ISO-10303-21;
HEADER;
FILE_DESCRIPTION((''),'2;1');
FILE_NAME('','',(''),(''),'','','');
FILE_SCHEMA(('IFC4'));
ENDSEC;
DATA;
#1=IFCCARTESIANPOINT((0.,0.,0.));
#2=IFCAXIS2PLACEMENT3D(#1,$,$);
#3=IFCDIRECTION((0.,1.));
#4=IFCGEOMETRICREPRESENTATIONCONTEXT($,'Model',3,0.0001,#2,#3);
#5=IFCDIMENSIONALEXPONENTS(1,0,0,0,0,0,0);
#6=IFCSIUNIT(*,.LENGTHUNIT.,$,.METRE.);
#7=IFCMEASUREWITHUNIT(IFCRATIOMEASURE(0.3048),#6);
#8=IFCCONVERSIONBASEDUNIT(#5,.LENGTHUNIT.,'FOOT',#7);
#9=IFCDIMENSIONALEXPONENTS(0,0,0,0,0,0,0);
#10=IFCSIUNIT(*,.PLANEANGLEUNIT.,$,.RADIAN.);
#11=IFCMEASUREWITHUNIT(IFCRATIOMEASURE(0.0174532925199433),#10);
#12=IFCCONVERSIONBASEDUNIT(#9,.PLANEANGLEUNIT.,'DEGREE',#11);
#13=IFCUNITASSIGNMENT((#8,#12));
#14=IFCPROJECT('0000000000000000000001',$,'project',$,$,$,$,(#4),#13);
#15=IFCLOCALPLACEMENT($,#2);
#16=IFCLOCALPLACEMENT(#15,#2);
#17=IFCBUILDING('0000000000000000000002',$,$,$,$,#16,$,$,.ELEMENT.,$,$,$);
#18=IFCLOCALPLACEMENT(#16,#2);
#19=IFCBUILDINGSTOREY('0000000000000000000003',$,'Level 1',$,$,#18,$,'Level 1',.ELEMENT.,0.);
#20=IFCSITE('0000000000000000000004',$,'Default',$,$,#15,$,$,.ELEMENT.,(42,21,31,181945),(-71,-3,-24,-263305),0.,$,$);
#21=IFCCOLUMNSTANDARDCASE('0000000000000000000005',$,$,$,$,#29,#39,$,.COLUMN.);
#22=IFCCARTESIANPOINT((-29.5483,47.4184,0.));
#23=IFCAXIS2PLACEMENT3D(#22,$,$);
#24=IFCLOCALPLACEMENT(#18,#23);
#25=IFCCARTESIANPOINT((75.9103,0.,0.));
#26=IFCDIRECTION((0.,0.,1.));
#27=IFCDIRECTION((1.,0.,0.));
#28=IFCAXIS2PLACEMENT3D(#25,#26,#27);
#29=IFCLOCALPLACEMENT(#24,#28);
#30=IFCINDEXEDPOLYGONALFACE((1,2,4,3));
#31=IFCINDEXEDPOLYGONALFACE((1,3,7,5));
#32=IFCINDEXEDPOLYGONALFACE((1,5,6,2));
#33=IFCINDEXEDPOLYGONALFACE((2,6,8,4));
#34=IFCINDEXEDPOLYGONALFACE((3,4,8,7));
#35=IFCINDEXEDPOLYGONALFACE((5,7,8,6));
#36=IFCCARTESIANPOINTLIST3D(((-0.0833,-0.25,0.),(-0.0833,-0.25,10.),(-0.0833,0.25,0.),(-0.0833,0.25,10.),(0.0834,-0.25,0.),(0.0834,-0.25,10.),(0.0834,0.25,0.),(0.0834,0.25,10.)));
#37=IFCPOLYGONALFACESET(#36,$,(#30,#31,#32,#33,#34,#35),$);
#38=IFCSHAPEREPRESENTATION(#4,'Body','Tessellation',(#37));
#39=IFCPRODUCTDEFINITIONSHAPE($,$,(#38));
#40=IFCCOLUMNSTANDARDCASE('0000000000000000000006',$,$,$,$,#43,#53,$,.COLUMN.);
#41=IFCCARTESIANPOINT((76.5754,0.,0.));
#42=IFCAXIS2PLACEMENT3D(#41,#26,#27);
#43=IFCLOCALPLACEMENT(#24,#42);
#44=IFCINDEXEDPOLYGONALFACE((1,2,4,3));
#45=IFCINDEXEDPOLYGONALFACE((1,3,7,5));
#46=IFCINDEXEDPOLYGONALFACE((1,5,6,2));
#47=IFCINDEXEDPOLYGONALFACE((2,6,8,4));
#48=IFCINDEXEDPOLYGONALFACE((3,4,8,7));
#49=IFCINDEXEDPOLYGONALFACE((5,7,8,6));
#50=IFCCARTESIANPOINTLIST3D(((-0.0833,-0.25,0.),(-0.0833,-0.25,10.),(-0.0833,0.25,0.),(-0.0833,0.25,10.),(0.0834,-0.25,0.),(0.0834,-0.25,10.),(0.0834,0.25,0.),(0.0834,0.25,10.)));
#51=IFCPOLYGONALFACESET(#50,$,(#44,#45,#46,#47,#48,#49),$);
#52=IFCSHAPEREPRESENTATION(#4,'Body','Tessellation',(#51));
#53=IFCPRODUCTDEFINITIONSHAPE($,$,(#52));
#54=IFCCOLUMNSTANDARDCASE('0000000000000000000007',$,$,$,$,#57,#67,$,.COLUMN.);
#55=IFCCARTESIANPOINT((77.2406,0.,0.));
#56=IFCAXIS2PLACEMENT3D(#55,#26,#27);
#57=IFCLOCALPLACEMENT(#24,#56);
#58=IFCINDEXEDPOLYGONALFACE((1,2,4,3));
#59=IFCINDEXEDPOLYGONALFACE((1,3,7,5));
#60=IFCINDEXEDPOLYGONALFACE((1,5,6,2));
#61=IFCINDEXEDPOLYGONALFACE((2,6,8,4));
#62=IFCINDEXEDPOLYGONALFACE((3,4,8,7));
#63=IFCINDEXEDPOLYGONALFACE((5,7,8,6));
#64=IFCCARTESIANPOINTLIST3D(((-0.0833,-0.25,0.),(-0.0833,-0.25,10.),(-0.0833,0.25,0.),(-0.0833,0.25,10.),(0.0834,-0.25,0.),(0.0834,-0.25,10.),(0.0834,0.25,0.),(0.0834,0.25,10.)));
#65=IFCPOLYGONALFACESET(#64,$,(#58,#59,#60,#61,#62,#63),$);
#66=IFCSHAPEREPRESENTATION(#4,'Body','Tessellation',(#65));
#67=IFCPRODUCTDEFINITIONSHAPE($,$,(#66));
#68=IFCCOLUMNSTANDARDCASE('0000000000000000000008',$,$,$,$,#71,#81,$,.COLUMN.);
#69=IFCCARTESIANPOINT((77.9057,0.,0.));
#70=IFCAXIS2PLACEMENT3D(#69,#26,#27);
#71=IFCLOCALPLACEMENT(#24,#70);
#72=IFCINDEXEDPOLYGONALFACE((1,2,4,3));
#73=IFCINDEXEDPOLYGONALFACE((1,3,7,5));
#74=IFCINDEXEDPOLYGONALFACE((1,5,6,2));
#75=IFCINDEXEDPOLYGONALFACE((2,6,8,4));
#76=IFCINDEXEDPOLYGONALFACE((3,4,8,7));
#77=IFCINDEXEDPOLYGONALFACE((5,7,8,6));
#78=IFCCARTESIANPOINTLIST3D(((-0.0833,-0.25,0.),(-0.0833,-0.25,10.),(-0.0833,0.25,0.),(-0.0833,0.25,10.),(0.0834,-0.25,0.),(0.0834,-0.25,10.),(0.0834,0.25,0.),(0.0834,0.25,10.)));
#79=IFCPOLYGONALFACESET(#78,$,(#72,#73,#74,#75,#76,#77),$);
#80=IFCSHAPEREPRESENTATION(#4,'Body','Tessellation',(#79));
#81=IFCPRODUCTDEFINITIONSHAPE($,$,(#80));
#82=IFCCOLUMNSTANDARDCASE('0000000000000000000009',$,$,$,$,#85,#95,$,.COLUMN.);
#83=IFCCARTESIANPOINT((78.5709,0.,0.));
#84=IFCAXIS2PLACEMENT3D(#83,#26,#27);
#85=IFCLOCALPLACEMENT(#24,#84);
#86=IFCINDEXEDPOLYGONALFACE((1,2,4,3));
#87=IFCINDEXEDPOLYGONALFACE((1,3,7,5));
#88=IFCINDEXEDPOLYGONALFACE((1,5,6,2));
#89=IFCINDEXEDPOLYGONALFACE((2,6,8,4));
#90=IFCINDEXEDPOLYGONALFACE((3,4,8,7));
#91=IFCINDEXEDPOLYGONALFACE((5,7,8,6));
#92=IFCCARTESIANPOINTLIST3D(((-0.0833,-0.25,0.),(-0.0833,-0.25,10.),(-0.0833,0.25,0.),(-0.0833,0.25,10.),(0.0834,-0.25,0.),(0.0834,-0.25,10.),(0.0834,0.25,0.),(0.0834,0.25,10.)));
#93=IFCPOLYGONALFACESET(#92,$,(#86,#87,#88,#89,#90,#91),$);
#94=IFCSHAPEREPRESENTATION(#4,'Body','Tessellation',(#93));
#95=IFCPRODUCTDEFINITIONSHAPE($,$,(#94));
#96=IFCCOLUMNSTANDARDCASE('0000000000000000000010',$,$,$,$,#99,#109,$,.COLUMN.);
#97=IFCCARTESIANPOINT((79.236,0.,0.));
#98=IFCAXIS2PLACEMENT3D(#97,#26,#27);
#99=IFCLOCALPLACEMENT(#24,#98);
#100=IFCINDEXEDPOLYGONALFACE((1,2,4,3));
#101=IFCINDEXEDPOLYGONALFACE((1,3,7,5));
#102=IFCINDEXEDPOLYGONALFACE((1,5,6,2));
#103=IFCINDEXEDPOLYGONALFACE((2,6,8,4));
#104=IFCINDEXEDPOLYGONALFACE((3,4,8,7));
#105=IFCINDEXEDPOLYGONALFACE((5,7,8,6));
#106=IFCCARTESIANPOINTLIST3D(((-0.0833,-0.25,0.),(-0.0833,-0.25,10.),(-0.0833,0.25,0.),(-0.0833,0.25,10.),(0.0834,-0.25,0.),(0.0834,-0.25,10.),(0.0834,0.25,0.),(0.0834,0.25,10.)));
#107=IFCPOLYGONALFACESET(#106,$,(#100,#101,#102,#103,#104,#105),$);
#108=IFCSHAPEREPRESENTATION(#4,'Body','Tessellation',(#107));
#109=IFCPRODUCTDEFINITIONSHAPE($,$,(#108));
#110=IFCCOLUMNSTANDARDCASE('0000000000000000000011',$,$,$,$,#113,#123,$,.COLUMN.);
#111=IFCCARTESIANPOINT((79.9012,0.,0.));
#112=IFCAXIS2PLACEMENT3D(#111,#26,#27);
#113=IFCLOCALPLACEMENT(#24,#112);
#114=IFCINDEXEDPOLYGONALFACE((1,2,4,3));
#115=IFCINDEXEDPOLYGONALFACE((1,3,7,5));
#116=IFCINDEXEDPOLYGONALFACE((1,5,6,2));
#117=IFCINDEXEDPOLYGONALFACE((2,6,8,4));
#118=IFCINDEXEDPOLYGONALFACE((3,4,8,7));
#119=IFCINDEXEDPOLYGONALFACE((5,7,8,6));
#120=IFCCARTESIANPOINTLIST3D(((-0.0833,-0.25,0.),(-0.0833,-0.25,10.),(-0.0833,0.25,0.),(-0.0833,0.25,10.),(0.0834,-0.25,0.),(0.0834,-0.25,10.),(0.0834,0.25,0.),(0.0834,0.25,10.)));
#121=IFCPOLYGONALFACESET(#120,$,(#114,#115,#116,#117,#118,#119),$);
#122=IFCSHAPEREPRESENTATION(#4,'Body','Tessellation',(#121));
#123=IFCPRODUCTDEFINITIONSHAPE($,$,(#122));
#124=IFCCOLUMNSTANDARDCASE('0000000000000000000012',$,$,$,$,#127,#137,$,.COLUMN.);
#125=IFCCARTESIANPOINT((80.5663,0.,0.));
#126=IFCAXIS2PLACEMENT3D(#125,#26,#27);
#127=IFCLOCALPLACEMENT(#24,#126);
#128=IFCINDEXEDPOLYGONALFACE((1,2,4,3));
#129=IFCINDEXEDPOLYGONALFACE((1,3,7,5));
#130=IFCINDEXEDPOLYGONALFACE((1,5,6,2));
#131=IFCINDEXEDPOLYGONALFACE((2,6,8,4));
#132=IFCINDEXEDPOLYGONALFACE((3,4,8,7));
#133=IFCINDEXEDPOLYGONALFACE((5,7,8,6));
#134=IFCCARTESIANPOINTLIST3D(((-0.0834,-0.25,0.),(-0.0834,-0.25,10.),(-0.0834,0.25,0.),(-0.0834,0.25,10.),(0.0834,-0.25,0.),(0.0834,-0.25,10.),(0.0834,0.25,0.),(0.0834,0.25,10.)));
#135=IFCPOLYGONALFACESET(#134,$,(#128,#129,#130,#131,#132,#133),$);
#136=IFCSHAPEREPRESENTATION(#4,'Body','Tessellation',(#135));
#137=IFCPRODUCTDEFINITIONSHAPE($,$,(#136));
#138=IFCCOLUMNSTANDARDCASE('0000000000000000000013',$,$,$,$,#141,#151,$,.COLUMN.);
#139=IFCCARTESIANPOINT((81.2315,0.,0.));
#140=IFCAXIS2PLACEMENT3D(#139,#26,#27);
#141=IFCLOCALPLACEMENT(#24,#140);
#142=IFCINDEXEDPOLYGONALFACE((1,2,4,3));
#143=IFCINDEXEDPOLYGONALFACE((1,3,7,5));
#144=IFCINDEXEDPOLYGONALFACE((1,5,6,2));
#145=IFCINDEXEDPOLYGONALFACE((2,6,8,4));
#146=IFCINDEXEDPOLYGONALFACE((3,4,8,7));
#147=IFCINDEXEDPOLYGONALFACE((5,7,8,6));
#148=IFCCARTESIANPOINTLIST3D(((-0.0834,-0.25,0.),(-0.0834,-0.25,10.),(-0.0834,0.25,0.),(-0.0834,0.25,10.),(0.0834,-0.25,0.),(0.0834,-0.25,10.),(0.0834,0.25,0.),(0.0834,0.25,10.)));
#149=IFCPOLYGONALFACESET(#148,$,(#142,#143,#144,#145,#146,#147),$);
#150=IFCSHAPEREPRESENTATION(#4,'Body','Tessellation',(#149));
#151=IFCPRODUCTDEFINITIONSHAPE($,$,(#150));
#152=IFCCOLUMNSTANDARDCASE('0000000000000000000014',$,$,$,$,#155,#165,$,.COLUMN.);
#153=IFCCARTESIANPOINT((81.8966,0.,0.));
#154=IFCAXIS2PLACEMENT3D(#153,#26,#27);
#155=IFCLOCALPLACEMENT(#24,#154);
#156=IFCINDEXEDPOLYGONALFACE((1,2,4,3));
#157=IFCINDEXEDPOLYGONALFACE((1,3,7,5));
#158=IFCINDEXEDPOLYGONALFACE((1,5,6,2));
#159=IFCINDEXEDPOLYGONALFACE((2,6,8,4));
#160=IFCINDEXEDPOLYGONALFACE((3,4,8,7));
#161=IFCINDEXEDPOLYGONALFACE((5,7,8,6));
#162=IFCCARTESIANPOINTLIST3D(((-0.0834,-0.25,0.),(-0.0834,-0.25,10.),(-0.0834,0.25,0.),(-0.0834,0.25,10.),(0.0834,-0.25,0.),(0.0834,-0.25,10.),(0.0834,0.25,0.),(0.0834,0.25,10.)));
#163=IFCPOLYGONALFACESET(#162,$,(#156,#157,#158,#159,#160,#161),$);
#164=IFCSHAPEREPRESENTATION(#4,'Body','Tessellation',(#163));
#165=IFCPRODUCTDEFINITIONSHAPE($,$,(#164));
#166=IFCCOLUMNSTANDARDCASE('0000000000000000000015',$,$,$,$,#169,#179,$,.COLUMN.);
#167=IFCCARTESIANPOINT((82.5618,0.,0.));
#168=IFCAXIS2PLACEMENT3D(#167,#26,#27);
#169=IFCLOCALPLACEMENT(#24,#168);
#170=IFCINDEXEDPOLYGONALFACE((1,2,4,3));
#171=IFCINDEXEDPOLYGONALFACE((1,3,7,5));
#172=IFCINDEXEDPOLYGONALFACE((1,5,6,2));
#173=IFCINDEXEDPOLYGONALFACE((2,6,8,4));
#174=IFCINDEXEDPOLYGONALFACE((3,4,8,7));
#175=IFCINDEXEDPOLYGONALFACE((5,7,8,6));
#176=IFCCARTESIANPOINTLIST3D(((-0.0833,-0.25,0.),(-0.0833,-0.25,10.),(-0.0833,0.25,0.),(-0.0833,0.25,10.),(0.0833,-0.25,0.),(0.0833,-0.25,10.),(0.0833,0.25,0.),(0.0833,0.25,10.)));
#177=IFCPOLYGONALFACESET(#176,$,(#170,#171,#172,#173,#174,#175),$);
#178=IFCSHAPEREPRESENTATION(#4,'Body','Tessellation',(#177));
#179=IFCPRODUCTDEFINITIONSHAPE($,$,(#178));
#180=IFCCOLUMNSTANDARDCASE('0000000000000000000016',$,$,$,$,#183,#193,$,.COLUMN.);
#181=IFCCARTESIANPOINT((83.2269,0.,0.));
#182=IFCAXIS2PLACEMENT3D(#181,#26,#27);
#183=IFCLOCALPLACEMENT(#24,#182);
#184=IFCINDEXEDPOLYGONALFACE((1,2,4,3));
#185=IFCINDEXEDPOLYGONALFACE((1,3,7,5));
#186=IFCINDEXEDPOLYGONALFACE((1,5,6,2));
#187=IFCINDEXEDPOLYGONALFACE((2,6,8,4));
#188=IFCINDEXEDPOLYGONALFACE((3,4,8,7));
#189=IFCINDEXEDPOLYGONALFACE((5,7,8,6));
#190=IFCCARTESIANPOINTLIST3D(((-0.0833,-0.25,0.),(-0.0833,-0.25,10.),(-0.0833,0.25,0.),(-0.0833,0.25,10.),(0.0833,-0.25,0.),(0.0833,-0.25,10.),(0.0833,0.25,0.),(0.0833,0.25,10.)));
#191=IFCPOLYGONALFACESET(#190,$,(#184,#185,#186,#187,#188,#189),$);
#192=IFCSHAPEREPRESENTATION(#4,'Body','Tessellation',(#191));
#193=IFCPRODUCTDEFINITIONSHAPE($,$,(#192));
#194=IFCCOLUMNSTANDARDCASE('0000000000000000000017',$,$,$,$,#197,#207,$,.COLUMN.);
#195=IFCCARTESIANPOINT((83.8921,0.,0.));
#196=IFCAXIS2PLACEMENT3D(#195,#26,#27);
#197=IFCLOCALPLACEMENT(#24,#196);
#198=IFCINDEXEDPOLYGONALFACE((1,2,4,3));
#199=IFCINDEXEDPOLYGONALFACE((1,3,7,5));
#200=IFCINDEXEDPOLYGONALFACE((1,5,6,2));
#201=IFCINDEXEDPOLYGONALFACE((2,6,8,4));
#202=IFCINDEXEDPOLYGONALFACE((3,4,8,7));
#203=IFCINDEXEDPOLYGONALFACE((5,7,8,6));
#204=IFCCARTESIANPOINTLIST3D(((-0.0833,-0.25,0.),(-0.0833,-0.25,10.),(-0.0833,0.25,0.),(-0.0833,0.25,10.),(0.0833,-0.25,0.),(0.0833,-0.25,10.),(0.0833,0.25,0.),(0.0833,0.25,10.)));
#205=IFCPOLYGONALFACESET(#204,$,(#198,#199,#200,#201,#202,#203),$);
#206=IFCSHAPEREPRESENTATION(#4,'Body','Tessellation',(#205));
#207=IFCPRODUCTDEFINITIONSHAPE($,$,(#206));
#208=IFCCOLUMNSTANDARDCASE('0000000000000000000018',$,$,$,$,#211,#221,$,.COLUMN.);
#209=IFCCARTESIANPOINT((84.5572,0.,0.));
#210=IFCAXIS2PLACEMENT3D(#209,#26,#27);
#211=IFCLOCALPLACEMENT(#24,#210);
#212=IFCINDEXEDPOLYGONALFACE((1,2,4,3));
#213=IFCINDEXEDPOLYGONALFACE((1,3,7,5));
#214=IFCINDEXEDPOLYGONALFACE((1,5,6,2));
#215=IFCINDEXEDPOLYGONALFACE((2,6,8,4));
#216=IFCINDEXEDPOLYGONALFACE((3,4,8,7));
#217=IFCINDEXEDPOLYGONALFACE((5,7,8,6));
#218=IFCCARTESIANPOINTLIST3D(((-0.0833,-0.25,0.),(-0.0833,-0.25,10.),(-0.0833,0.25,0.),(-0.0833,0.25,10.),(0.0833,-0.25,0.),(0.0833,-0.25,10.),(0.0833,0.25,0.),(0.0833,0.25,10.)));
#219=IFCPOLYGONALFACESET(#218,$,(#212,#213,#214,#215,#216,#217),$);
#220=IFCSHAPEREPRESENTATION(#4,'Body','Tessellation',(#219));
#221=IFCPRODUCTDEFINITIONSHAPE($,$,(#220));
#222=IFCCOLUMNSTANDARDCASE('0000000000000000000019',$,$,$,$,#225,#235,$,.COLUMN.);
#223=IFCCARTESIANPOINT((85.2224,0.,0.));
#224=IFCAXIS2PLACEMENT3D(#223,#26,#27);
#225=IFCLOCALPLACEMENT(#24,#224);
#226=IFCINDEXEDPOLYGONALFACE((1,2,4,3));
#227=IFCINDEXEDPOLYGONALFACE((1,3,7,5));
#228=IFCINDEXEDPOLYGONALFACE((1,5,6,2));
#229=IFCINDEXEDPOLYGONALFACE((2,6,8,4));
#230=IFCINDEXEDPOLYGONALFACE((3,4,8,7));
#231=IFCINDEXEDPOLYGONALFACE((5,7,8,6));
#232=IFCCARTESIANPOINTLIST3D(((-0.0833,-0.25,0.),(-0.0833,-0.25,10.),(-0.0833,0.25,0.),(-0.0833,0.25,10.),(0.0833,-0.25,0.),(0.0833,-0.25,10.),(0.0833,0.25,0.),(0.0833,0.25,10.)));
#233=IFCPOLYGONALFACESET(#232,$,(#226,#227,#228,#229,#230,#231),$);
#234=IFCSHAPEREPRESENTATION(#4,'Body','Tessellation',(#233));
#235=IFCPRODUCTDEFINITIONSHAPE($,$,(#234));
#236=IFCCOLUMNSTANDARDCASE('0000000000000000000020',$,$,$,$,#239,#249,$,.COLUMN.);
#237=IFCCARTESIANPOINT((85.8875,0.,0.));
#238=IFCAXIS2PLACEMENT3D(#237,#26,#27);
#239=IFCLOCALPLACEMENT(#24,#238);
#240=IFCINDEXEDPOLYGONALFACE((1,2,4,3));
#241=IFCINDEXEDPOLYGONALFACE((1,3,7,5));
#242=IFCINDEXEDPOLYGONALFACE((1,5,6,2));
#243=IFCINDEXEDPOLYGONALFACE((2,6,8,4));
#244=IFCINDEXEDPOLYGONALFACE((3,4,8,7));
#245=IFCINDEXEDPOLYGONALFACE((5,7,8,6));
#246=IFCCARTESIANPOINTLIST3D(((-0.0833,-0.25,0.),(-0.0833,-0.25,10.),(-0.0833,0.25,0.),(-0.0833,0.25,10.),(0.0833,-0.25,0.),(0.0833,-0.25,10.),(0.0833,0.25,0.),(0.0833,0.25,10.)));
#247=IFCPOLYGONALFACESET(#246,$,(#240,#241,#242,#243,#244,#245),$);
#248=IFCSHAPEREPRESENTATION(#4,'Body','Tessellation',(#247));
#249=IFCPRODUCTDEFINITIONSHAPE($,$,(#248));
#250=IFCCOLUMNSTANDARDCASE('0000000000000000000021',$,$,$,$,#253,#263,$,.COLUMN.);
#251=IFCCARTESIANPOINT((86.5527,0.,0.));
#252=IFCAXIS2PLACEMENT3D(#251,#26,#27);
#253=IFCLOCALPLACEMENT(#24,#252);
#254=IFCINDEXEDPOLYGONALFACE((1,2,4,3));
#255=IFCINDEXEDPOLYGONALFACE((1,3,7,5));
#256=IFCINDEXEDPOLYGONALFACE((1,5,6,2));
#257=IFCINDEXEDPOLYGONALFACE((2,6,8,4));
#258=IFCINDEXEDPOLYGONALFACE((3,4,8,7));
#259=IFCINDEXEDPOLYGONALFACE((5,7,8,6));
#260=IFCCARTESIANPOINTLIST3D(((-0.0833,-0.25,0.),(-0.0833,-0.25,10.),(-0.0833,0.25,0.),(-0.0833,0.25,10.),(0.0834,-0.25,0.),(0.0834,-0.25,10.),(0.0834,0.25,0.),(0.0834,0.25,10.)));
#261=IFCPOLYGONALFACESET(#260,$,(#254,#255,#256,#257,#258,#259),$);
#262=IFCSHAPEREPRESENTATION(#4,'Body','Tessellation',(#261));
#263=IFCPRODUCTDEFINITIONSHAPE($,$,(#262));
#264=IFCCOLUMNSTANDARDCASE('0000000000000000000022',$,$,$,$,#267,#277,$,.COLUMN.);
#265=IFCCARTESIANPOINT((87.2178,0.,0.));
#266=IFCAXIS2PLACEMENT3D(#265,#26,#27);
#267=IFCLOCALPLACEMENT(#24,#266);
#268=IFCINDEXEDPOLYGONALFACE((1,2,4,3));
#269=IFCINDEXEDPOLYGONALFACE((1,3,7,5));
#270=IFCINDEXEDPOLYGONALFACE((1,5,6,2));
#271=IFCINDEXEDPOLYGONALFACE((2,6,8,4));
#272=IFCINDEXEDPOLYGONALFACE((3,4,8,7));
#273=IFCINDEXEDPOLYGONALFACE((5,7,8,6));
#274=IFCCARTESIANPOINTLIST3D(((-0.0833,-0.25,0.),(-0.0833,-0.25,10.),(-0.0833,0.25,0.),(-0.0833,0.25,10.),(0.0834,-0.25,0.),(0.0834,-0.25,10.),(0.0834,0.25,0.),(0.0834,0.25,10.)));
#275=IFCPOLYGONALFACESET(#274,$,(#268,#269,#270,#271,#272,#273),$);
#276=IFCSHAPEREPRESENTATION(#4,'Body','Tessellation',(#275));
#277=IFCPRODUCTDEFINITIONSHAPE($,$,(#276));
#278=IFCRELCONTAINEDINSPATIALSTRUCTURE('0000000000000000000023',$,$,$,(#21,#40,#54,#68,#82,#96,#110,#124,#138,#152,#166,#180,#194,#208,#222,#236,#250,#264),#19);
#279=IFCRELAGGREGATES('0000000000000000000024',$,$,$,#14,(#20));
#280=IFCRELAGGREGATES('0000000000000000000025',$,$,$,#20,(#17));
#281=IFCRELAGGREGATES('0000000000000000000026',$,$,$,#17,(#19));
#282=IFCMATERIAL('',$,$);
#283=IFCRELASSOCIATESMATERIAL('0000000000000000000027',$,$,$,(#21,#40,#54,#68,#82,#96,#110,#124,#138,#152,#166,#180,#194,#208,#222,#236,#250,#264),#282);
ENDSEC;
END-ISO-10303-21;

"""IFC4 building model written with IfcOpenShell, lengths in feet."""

from ifc_helpers import new_model, entity, si_unit, converted_unit, direction, frame, origin, place, context, project, spatial, rectangle, extrude, material, element, save


model = new_model("IFC4")

# Units and contexts
model_context = context("Model", 3, precision=0.0001, world=origin(), true_north=direction((0.0, 1.0)))
ifc_project = project(units=[converted_unit("LENGTHUNIT", "FOOT", entity("IfcRatioMeasure", 0.3048), si_unit("LENGTHUNIT", "METRE"), dimensions=[1, 0, 0, 0, 0, 0, 0]), converted_unit("PLANEANGLEUNIT", "DEGREE", entity("IfcRatioMeasure", 0.0174532925199433), si_unit("PLANEANGLEUNIT", "RADIAN"), dimensions=[0, 0, 0, 0, 0, 0, 0])], contexts=[model_context])

# Site, building, storey
site_placement = place(None, origin())
site = spatial("IfcSite", under=ifc_project, at=site_placement, Name="Default", CompositionType="ELEMENT", RefLatitude=(42, 21, 31, 181945), RefLongitude=(-71, -3, -24, -263305), RefElevation=0.0)
building_placement = place(site_placement, origin())
building = spatial("IfcBuilding", under=site, at=building_placement, CompositionType="ELEMENT")
storey_placement = place(building_placement, origin())
storey = spatial("IfcBuildingStorey", under=building, at=storey_placement, Name="Level 1", LongName="Level 1", CompositionType="ELEMENT", Elevation=0.0)

# Columns
ifc_material = material(Name="")
placement = place(storey_placement, frame((-29.5483, 47.4184, 0.0)))
for number, where, z_axis, x_axis in (
    (1, (75.9103, 0.0, 0.0), (0.0, 0.0, 1.0), (1.0, 0.0, 0.0)),
    (2, (76.5754, 0.0, 0.0), (0.0, 0.0, 1.0), (1.0, 0.0, 0.0)),
    (3, (77.2406, 0.0, 0.0), (0.0, 0.0, 1.0), (1.0, 0.0, 0.0)),
    (4, (77.9057, 0.0, 0.0), (0.0, 0.0, 1.0), (1.0, 0.0, 0.0)),
    (5, (78.5709, 0.0, 0.0), (0.0, 0.0, 1.0), (1.0, 0.0, 0.0)),
    (6, (79.236, 0.0, 0.0), (0.0, 0.0, 1.0), (1.0, 0.0, 0.0)),
    (7, (79.9012, 0.0, 0.0), (0.0, 0.0, 1.0), (1.0, 0.0, 0.0)),
    (8, (80.5663, 0.0, 0.0), (0.0, 0.0, 1.0), (1.0, 0.0, 0.0)),
    (9, (81.2315, 0.0, 0.0), (0.0, 0.0, 1.0), (1.0, 0.0, 0.0)),
    (10, (81.8966, 0.0, 0.0), (0.0, 0.0, 1.0), (1.0, 0.0, 0.0)),
    (11, (82.5618, 0.0, 0.0), (0.0, 0.0, 1.0), (1.0, 0.0, 0.0)),
    (12, (83.2269, 0.0, 0.0), (0.0, 0.0, 1.0), (1.0, 0.0, 0.0)),
    (13, (83.8921, 0.0, 0.0), (0.0, 0.0, 1.0), (1.0, 0.0, 0.0)),
    (14, (84.5572, 0.0, 0.0), (0.0, 0.0, 1.0), (1.0, 0.0, 0.0)),
    (15, (85.2224, 0.0, 0.0), (0.0, 0.0, 1.0), (1.0, 0.0, 0.0)),
    (16, (85.8875, 0.0, 0.0), (0.0, 0.0, 1.0), (1.0, 0.0, 0.0)),
    (17, (86.5527, 0.0, 0.0), (0.0, 0.0, 1.0), (1.0, 0.0, 0.0)),
    (18, (87.2178, 0.0, 0.0), (0.0, 0.0, 1.0), (1.0, 0.0, 0.0)),
):
    element("IfcColumnStandardCase", number, at=place(placement, frame(where, z_axis=z_axis, x_axis=x_axis)), inside=storey, material=ifc_material, PredefinedType="COLUMN", context=model_context, shape_type="SweptSolid", body=[
        extrude(rectangle(XDim=0.1667, YDim=0.5), origin(), (0.0, 0.0, 1.0), 10.0),
    ])

save(model, "model.ifc")
